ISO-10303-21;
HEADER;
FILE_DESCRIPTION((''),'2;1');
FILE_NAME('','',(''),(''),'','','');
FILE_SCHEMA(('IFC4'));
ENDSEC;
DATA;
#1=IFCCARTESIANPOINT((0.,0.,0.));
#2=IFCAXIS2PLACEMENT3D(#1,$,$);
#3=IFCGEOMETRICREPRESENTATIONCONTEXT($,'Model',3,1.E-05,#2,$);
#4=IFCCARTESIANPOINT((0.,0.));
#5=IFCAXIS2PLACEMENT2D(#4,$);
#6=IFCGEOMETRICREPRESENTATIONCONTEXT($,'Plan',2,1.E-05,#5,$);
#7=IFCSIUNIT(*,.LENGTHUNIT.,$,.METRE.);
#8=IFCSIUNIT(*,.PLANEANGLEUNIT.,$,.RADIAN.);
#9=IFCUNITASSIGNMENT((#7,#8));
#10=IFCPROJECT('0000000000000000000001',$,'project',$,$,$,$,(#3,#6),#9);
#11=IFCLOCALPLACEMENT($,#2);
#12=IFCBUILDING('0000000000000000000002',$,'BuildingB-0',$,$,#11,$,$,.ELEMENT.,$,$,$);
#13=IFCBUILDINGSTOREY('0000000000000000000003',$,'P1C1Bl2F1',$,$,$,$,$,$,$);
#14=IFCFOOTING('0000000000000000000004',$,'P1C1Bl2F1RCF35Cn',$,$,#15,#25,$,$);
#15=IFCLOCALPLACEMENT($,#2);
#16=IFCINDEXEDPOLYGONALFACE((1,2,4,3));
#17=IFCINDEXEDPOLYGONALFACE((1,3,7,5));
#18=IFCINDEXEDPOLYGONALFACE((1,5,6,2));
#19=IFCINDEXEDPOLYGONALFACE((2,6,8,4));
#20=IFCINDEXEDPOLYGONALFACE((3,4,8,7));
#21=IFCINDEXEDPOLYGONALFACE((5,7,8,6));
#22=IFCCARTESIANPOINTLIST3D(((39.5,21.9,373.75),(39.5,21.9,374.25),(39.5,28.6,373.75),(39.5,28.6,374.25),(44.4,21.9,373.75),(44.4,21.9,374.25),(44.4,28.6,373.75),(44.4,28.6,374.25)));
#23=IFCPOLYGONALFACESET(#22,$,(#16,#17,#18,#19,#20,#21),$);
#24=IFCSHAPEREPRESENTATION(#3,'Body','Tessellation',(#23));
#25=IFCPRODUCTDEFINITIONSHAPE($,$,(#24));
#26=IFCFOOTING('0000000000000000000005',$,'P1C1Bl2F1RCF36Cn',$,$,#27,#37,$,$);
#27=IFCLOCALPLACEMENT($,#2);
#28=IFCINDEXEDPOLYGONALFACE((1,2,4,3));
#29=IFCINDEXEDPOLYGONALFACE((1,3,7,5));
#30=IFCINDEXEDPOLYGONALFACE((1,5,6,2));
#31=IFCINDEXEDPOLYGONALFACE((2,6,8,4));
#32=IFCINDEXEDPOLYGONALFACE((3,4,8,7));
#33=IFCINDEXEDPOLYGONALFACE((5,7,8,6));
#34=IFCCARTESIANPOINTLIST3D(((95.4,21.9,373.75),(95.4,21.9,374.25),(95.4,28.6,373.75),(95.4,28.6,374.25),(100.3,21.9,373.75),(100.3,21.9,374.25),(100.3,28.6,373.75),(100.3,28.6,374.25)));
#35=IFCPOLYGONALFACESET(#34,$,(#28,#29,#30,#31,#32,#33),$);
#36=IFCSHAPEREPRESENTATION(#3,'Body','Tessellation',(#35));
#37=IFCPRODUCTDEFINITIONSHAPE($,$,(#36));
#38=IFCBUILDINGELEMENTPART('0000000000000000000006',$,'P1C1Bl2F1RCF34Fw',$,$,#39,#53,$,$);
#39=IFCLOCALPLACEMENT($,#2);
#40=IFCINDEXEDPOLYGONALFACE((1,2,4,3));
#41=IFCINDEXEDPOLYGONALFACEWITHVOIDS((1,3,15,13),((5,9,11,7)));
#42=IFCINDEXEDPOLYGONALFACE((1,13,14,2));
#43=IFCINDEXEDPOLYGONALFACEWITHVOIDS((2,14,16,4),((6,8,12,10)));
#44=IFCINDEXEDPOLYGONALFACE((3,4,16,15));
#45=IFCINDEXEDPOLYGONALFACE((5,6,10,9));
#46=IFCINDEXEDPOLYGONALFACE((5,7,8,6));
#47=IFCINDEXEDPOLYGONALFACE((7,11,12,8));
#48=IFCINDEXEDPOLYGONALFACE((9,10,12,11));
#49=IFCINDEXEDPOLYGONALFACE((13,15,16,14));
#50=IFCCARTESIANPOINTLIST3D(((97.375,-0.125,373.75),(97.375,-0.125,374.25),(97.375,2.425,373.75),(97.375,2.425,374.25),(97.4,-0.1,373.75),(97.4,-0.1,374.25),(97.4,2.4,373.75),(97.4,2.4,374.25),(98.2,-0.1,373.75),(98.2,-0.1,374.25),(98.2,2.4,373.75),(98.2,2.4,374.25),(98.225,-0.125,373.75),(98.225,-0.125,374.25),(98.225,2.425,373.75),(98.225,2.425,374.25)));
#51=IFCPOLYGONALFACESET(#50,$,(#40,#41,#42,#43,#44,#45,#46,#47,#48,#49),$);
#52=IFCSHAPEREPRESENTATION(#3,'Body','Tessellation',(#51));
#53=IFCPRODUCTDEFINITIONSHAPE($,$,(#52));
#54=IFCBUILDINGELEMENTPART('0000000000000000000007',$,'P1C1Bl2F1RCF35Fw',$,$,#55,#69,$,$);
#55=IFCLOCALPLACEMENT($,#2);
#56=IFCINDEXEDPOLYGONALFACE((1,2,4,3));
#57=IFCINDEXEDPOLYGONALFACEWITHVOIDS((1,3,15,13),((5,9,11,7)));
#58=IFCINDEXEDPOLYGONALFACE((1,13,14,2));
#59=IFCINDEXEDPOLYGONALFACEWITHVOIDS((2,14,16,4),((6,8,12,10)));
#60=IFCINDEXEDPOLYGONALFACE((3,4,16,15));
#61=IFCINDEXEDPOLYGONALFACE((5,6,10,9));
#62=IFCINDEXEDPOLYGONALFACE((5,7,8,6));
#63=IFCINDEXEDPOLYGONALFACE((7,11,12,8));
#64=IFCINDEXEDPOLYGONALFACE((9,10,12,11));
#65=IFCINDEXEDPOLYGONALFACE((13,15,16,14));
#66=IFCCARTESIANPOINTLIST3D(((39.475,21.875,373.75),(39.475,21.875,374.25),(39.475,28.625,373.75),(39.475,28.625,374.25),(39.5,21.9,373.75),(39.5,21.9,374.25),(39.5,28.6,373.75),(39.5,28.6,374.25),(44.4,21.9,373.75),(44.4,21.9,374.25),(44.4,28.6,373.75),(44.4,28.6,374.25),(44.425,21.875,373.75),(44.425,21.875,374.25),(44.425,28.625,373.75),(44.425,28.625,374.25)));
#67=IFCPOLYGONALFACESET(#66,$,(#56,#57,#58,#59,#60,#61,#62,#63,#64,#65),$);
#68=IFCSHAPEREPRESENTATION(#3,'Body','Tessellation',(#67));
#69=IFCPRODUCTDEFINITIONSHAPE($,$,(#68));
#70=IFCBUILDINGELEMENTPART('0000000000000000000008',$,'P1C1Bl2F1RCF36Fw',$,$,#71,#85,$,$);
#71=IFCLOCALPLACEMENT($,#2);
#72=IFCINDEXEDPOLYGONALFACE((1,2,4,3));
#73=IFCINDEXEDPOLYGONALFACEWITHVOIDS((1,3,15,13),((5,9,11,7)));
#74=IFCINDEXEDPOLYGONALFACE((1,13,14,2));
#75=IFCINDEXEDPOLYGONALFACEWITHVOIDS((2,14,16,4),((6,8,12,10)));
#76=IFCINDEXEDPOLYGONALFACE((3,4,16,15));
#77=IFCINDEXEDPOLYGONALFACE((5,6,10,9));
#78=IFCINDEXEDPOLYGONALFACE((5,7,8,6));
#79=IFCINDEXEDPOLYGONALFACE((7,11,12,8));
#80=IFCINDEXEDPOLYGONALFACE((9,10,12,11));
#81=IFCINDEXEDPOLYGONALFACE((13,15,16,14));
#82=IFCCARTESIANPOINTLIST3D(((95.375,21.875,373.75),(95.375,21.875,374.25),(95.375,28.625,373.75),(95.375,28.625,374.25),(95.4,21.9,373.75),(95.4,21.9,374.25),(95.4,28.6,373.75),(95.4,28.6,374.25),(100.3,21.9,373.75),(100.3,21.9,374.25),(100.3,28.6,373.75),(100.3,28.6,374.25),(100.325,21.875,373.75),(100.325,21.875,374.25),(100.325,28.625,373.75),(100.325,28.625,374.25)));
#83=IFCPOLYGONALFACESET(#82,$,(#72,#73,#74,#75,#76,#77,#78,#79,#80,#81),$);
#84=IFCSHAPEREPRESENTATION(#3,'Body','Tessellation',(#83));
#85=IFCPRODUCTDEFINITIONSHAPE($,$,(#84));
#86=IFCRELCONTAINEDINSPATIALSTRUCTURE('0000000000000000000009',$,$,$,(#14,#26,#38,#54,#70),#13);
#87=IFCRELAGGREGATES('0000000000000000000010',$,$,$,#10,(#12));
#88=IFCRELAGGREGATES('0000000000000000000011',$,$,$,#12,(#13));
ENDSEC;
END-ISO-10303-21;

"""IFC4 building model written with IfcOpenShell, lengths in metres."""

from ifc_helpers import new_model, si_unit, origin, origin_2d, place, context, project, spatial, polyline, outline, extrude, element, save


model = new_model("IFC4")

# Units and contexts
model_context = context("Model", 3, precision=1e-05, world=origin())
plan_context = context("Plan", 2, precision=1e-05, world=origin_2d())
ifc_project = project(units=[si_unit("LENGTHUNIT", "METRE"), si_unit("PLANEANGLEUNIT", "RADIAN")], contexts=[model_context, plan_context])

# Building, storey
building_placement = place(None, origin())
building = spatial("IfcBuilding", under=ifc_project, at=building_placement, Name="BuildingB-0", CompositionType="ELEMENT")
storey = spatial("IfcBuildingStorey", under=building, Name="P1C1Bl2F1")

# Footings
element("IfcFooting", 1, inside=storey, Name="P1C1Bl2F1RCF35Cn", context=model_context, shape_type="SweptSolid", body=[
    extrude(outline(polyline([(44.4, 21.9, 373.75), (44.4, 28.6, 373.75), (39.5, 28.6, 373.75), (39.5, 21.9, 373.75), (44.4, 21.9, 373.75)])), None, (0.0, 0.0, 1.0), 0.5),
])
element("IfcFooting", 2, inside=storey, Name="P1C1Bl2F1RCF36Cn", context=model_context, shape_type="SweptSolid", body=[
    extrude(outline(polyline([(95.4, 21.9, 373.75), (95.4, 28.6, 373.75), (100.3, 28.6, 373.75), (100.3, 21.9, 373.75), (95.4, 21.9, 373.75)])), None, (0.0, 0.0, 1.0), 0.5),
])

# Building element part, opening
building_element_part_1 = element("IfcBuildingElementPart", 3, inside=storey, Name="P1C1Bl2F1RCF34Fw", context=model_context, shape_type="SweptSolid", body=[
    extrude(outline(polyline([(97.375, 2.425, 373.75), (98.225, 2.425, 373.75), (98.225, -0.125, 373.75), (97.375, -0.125, 373.75), (97.375, 2.425, 373.75)])), None, (0.0, 0.0, 1.0), 0.5),
])
element("IfcOpeningElement", 4, inside=storey, cuts=building_element_part_1, context=model_context, shape_type="SweptSolid", body=[
    extrude(outline(polyline([(97.4, 2.4, 373.75), (98.2, 2.4, 373.75), (98.2, -0.1, 373.75), (97.4, -0.1, 373.75), (97.4, 2.4, 373.75)])), None, (0.0, 0.0, 1.0), 0.5),
])

# Building element part, opening
building_element_part_2 = element("IfcBuildingElementPart", 5, inside=storey, Name="P1C1Bl2F1RCF35Fw", context=model_context, shape_type="SweptSolid", body=[
    extrude(outline(polyline([(44.425, 21.875, 373.75), (44.425, 28.625, 373.75), (39.475, 28.625, 373.75), (39.475, 21.875, 373.75), (44.425, 21.875, 373.75)])), None, (0.0, 0.0, 1.0), 0.5),
])
element("IfcOpeningElement", 6, inside=storey, cuts=building_element_part_2, context=model_context, shape_type="SweptSolid", body=[
    extrude(outline(polyline([(44.4, 21.9, 373.75), (44.4, 28.6, 373.75), (39.5, 28.6, 373.75), (39.5, 21.9, 373.75), (44.4, 21.9, 373.75)])), None, (0.0, 0.0, 1.0), 0.5),
])

# Building element part, opening
building_element_part_3 = element("IfcBuildingElementPart", 7, inside=storey, Name="P1C1Bl2F1RCF36Fw", context=model_context, shape_type="SweptSolid", body=[
    extrude(outline(polyline([(95.375, 21.875, 373.75), (95.375, 28.625, 373.75), (100.325, 28.625, 373.75), (100.325, 21.875, 373.75), (95.375, 21.875, 373.75)])), None, (0.0, 0.0, 1.0), 0.5),
])
element("IfcOpeningElement", 8, inside=storey, cuts=building_element_part_3, context=model_context, shape_type="SweptSolid", body=[
    extrude(outline(polyline([(95.4, 21.9, 373.75), (95.4, 28.6, 373.75), (100.3, 28.6, 373.75), (100.3, 21.9, 373.75), (95.4, 21.9, 373.75)])), None, (0.0, 0.0, 1.0), 0.5),
])

save(model, "model.ifc")
